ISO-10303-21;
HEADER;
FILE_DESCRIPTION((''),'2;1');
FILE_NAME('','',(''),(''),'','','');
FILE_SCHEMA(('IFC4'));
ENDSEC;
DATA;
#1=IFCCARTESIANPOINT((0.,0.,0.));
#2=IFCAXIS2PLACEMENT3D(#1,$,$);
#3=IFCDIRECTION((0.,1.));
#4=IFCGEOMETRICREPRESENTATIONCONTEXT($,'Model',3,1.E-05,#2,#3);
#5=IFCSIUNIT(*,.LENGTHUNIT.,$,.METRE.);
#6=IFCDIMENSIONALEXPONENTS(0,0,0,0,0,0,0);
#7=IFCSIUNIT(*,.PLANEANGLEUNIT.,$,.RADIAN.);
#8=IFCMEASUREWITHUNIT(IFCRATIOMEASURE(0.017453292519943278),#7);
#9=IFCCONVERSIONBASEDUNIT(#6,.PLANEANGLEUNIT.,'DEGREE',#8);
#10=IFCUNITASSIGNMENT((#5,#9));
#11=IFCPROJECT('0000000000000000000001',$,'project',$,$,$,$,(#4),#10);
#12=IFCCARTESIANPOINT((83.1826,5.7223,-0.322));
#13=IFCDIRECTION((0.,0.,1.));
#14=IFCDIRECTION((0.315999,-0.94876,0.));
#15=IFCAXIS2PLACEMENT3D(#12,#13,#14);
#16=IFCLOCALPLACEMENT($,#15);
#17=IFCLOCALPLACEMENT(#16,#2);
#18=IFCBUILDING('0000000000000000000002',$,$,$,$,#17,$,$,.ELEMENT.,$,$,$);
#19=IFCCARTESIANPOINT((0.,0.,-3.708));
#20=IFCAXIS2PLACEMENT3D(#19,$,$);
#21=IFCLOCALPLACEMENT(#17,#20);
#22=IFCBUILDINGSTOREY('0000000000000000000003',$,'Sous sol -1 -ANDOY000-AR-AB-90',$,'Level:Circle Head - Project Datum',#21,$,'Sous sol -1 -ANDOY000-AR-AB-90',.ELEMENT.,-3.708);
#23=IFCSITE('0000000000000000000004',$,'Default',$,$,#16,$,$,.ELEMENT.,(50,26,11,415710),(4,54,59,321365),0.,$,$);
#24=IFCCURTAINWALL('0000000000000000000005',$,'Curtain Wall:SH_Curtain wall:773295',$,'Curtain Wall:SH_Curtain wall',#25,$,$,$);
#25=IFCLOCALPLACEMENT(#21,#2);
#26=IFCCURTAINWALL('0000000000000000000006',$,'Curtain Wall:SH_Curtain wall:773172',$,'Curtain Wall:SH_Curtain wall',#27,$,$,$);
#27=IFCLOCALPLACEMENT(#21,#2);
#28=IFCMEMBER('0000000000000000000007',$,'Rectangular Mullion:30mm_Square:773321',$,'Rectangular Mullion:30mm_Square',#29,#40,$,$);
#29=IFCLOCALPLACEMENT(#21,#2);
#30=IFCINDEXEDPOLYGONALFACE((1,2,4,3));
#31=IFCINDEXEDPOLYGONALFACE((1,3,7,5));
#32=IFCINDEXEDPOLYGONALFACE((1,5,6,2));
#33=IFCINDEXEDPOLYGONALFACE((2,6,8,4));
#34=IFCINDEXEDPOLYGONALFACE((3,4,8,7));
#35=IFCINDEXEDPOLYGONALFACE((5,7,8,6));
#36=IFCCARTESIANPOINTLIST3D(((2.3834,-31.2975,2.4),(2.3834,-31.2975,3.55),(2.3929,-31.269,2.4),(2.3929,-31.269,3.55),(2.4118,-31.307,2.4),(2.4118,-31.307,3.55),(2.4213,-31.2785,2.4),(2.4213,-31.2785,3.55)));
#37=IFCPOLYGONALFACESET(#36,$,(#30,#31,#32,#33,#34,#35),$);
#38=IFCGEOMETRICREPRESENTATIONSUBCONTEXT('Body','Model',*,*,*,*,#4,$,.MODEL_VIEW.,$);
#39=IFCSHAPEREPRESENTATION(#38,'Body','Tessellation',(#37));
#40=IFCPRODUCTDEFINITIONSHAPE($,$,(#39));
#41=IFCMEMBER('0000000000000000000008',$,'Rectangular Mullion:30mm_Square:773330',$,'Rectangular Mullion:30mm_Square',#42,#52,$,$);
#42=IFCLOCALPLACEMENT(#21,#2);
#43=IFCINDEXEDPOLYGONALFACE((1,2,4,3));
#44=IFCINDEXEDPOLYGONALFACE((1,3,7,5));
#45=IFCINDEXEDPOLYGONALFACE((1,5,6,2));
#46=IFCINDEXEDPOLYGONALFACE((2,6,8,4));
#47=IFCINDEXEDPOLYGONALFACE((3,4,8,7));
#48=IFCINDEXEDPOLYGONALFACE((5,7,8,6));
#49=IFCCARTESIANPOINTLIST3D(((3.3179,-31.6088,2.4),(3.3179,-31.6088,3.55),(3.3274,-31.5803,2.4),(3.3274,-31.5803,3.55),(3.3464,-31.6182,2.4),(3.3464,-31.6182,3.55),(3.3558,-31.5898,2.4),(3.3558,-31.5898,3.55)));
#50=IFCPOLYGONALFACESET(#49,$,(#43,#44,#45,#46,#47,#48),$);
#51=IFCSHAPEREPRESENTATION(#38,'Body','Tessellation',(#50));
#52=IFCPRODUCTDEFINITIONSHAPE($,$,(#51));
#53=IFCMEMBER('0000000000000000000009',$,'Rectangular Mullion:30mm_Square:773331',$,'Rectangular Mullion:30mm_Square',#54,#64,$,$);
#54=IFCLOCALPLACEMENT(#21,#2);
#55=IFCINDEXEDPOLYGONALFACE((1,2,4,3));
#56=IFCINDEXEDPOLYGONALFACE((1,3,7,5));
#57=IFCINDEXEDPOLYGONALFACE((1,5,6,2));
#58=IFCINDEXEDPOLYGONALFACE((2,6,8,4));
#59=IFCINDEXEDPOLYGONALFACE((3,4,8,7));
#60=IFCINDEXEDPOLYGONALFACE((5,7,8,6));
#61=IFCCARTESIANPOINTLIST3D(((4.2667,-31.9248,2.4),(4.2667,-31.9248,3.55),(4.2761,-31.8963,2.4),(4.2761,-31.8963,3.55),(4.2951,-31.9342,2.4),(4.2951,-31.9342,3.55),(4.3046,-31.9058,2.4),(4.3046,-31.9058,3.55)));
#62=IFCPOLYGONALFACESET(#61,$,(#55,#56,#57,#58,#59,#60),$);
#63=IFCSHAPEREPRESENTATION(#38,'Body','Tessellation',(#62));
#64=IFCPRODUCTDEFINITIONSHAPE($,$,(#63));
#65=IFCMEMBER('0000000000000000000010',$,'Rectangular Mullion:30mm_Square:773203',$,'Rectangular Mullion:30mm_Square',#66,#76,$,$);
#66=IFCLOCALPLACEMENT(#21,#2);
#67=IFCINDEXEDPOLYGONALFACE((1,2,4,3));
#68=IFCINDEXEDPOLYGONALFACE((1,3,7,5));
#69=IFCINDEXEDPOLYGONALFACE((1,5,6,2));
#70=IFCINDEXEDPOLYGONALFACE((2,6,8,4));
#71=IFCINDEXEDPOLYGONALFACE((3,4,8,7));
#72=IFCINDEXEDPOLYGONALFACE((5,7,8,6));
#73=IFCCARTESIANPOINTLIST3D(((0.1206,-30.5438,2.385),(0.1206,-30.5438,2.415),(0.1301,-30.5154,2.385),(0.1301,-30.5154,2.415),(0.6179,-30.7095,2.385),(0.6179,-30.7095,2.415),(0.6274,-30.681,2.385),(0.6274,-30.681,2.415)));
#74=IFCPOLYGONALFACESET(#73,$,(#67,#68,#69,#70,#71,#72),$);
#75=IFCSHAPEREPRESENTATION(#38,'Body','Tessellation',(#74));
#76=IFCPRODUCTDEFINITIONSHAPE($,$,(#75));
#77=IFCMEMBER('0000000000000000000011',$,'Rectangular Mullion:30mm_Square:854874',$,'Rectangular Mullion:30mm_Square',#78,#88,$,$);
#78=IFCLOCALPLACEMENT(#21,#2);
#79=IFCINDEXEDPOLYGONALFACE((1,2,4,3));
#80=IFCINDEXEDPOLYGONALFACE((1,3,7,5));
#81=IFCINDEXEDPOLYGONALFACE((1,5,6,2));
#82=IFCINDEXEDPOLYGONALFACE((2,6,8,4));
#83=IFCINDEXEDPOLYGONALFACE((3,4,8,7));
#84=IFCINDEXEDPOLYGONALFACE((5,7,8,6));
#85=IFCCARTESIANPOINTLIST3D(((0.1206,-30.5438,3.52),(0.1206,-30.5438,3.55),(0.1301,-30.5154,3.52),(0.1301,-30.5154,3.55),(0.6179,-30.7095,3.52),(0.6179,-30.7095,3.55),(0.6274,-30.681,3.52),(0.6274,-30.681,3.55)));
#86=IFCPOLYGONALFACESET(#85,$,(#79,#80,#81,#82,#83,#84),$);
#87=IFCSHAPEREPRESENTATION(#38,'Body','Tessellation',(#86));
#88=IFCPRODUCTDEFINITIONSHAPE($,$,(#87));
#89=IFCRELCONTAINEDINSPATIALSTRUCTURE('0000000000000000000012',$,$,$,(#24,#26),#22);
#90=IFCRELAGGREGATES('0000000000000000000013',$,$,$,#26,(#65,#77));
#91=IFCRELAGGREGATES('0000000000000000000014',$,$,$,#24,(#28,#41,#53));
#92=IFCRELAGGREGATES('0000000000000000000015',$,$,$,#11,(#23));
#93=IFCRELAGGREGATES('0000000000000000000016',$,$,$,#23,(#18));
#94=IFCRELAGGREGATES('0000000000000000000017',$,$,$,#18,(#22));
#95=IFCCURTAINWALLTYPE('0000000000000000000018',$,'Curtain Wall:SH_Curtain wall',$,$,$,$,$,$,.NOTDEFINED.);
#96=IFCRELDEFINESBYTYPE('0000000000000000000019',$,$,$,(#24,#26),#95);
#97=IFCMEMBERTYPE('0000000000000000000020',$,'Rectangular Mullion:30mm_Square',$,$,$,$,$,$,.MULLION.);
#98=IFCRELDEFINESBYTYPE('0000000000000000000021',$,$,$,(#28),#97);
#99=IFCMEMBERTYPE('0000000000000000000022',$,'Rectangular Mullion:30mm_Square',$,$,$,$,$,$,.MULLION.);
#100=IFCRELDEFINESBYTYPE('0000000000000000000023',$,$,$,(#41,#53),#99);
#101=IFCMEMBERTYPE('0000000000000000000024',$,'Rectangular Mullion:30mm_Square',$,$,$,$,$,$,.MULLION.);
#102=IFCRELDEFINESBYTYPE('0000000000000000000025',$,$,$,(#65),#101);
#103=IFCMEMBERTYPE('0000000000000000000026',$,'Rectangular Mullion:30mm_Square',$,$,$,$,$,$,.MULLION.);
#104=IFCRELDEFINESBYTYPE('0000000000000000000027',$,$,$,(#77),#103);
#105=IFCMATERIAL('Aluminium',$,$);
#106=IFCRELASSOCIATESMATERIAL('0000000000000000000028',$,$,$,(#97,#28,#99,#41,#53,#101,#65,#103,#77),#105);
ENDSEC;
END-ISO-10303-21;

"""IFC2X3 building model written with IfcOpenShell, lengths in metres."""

from ifc_helpers import new_model, entity, si_unit, converted_unit, direction, frame, origin, origin_2d_with_axis, place, context, subcontext, project, spatial, rectangle, extrude, source, transform, mapped, material, type_object, type_shapes, element, aggregate, save


model = new_model("IFC2X3")

# Units and contexts
model_context = context("Model", 3, precision=1e-05, world=origin(), true_north=direction((0.0, 1.0)))
body_context = subcontext(model_context, "Body", "Model", "MODEL_VIEW")
ifc_project = project(units=[si_unit("LENGTHUNIT", "METRE"), converted_unit("PLANEANGLEUNIT", "DEGREE", entity("IfcRatioMeasure", 0.017453292519943278), si_unit("PLANEANGLEUNIT", "RADIAN"), dimensions=[0, 0, 0, 0, 0, 0, 0])], contexts=[model_context])

# Site, building, storey
site_placement = place(None, frame((83.1826, 5.7223, -0.322), z_axis=(0.0, 0.0, 1.0), x_axis=(0.315999, -0.94876, 0.0)))
site = spatial("IfcSite", under=ifc_project, at=site_placement, Name="Default", CompositionType="ELEMENT", RefLatitude=(50, 26, 11, 415710), RefLongitude=(4, 54, 59, 321365), RefElevation=0.0)
building_placement = place(site_placement, origin())
building = spatial("IfcBuilding", under=site, at=building_placement, CompositionType="ELEMENT")
storey_placement = place(building_placement, frame((0.0, 0.0, -3.708)))
storey = spatial("IfcBuildingStorey", under=building, at=storey_placement, Name="Sous sol -1 -ANDOY000-AR-AB-90", ObjectType="Level:Circle Head - Project Datum", LongName="Sous sol -1 -ANDOY000-AR-AB-90", CompositionType="ELEMENT", Elevation=-3.708)

# Curtain walls
curtain_wall_type = type_object("IfcCurtainWallType", Name="Curtain Wall:SH_Curtain wall", PredefinedType="NOTDEFINED")
curtain_wall_1_placement = place(storey_placement, frame((0.0, 0.0, 3.708)))
curtain_wall_1 = element("IfcCurtainWall", 1, at=curtain_wall_1_placement, inside=storey, type_object=curtain_wall_type, Name="Curtain Wall:SH_Curtain wall:773295", ObjectType="Curtain Wall:SH_Curtain wall")
ifc_material_1 = material(Name="Aluminium")
curtain_wall_2_placement = place(storey_placement, frame((0.0, 0.0, 3.708)))
curtain_wall_2 = element("IfcCurtainWall", 2, at=curtain_wall_2_placement, inside=storey, type_object=curtain_wall_type, Name="Curtain Wall:SH_Curtain wall:773172", ObjectType="Curtain Wall:SH_Curtain wall")

# Members
member_type_1 = type_object("IfcMemberType", Name="Rectangular Mullion:30mm_Square", PredefinedType="MULLION", material=ifc_material_1)
shared_shape_1 = source(origin(), body_context, "Body", "SweptSolid", [
    extrude(rectangle(XDim=0.03, YDim=0.03, at=origin_2d_with_axis()), frame((-0.015, 0.0, -1.15), z_axis=(0.0, 0.0, 1.0), x_axis=(0.0, -1.0, 0.0)), (0.0, 0.0, 1.0), 1.15),
])
type_shapes(member_type_1, [shared_shape_1])
member_1_placement = place(curtain_wall_1_placement, frame((2.3881, -31.2833, -0.158), z_axis=(0.0, 0.0, 1.0), x_axis=(-0.948759, 0.316, 0.0)))
member_1 = element("IfcMember", 3, at=member_1_placement, type_object=member_type_1, material=ifc_material_1, Name="Rectangular Mullion:30mm_Square:773321", ObjectType="Rectangular Mullion:30mm_Square", context=body_context, shape_type="MappedRepresentation", body=[
    mapped(shared_shape_1, transform((0.0, 0.0, 0.0), scale=1.0)),
])
member_type_2 = type_object("IfcMemberType", Name="Rectangular Mullion:30mm_Square", PredefinedType="MULLION", material=ifc_material_1)
shared_shape_2 = source(origin(), body_context, "Body", "SweptSolid", [
    extrude(rectangle(XDim=0.03, YDim=0.03, at=origin_2d_with_axis()), frame((0.0, 0.0, -1.15), z_axis=(0.0, 0.0, 1.0), x_axis=(0.0, -1.0, 0.0)), (0.0, 0.0, 1.0), 1.15),
])
type_shapes(member_type_2, [shared_shape_2])
member_2_placement = place(curtain_wall_1_placement, frame((3.3369, -31.5993, -1.308), z_axis=(0.0, 0.0, -1.0), x_axis=(0.948759, -0.316, 0.0)))
member_2 = element("IfcMember", 4, at=member_2_placement, type_object=member_type_2, material=ifc_material_1, Name="Rectangular Mullion:30mm_Square:773330", ObjectType="Rectangular Mullion:30mm_Square", context=body_context, shape_type="MappedRepresentation", body=[
    mapped(shared_shape_2, transform((0.0, 0.0, 0.0), scale=1.0)),
])
member_3_placement = place(curtain_wall_1_placement, frame((4.2856, -31.9153, -1.308), z_axis=(0.0, 0.0, -1.0), x_axis=(0.948759, -0.316, 0.0)))
member_3 = element("IfcMember", 5, at=member_3_placement, type_object=member_type_2, material=ifc_material_1, Name="Rectangular Mullion:30mm_Square:773331", ObjectType="Rectangular Mullion:30mm_Square", context=body_context, shape_type="MappedRepresentation", body=[
    mapped(shared_shape_2, transform((0.0, 0.0, 0.0), scale=1.0)),
])
member_type_3 = type_object("IfcMemberType", Name="Rectangular Mullion:30mm_Square", PredefinedType="MULLION", material=ifc_material_1)
shared_shape_3 = source(origin(), body_context, "Body", "SweptSolid", [
    extrude(rectangle(XDim=0.03, YDim=0.03, at=origin_2d_with_axis()), frame((0.0, 0.0, -0.5242), z_axis=(0.0, 0.0, 1.0), x_axis=(0.0, -1.0, 0.0)), (0.0, 0.0, 1.0), 0.5242),
])
type_shapes(member_type_3, [shared_shape_3])
member_4_placement = place(curtain_wall_2_placement, frame((0.6227, -30.6953, -1.308), z_axis=(0.948759, -0.316, 0.0), x_axis=(0.0, 0.0, 1.0)))
member_4 = element("IfcMember", 6, at=member_4_placement, type_object=member_type_3, material=ifc_material_1, Name="Rectangular Mullion:30mm_Square:773203", ObjectType="Rectangular Mullion:30mm_Square", context=body_context, shape_type="MappedRepresentation", body=[
    mapped(shared_shape_3, transform((0.0, 0.0, 0.0), scale=1.0)),
])
member_type_4 = type_object("IfcMemberType", Name="Rectangular Mullion:30mm_Square", PredefinedType="MULLION", material=ifc_material_1)
shared_shape_4 = source(origin(), body_context, "Body", "SweptSolid", [
    extrude(rectangle(XDim=0.03, YDim=0.03, at=origin_2d_with_axis()), frame((-0.015, 0.0, -0.5242), z_axis=(0.0, 0.0, 1.0), x_axis=(0.0, -1.0, 0.0)), (0.0, 0.0, 1.0), 0.5242),
])
type_shapes(member_type_4, [shared_shape_4])
member_5_placement = place(curtain_wall_2_placement, frame((0.6227, -30.6953, -0.158), z_axis=(0.948759, -0.316, 0.0), x_axis=(0.0, 0.0, 1.0)))
member_5 = element("IfcMember", 7, at=member_5_placement, type_object=member_type_4, material=ifc_material_1, Name="Rectangular Mullion:30mm_Square:854874", ObjectType="Rectangular Mullion:30mm_Square", context=body_context, shape_type="MappedRepresentation", body=[
    mapped(shared_shape_4, transform((0.0, 0.0, 0.0), scale=1.0)),
])
aggregate(curtain_wall_2, [member_4, member_5])

aggregate(curtain_wall_1, [member_1, member_2, member_3])

save(model, "model.ifc")
